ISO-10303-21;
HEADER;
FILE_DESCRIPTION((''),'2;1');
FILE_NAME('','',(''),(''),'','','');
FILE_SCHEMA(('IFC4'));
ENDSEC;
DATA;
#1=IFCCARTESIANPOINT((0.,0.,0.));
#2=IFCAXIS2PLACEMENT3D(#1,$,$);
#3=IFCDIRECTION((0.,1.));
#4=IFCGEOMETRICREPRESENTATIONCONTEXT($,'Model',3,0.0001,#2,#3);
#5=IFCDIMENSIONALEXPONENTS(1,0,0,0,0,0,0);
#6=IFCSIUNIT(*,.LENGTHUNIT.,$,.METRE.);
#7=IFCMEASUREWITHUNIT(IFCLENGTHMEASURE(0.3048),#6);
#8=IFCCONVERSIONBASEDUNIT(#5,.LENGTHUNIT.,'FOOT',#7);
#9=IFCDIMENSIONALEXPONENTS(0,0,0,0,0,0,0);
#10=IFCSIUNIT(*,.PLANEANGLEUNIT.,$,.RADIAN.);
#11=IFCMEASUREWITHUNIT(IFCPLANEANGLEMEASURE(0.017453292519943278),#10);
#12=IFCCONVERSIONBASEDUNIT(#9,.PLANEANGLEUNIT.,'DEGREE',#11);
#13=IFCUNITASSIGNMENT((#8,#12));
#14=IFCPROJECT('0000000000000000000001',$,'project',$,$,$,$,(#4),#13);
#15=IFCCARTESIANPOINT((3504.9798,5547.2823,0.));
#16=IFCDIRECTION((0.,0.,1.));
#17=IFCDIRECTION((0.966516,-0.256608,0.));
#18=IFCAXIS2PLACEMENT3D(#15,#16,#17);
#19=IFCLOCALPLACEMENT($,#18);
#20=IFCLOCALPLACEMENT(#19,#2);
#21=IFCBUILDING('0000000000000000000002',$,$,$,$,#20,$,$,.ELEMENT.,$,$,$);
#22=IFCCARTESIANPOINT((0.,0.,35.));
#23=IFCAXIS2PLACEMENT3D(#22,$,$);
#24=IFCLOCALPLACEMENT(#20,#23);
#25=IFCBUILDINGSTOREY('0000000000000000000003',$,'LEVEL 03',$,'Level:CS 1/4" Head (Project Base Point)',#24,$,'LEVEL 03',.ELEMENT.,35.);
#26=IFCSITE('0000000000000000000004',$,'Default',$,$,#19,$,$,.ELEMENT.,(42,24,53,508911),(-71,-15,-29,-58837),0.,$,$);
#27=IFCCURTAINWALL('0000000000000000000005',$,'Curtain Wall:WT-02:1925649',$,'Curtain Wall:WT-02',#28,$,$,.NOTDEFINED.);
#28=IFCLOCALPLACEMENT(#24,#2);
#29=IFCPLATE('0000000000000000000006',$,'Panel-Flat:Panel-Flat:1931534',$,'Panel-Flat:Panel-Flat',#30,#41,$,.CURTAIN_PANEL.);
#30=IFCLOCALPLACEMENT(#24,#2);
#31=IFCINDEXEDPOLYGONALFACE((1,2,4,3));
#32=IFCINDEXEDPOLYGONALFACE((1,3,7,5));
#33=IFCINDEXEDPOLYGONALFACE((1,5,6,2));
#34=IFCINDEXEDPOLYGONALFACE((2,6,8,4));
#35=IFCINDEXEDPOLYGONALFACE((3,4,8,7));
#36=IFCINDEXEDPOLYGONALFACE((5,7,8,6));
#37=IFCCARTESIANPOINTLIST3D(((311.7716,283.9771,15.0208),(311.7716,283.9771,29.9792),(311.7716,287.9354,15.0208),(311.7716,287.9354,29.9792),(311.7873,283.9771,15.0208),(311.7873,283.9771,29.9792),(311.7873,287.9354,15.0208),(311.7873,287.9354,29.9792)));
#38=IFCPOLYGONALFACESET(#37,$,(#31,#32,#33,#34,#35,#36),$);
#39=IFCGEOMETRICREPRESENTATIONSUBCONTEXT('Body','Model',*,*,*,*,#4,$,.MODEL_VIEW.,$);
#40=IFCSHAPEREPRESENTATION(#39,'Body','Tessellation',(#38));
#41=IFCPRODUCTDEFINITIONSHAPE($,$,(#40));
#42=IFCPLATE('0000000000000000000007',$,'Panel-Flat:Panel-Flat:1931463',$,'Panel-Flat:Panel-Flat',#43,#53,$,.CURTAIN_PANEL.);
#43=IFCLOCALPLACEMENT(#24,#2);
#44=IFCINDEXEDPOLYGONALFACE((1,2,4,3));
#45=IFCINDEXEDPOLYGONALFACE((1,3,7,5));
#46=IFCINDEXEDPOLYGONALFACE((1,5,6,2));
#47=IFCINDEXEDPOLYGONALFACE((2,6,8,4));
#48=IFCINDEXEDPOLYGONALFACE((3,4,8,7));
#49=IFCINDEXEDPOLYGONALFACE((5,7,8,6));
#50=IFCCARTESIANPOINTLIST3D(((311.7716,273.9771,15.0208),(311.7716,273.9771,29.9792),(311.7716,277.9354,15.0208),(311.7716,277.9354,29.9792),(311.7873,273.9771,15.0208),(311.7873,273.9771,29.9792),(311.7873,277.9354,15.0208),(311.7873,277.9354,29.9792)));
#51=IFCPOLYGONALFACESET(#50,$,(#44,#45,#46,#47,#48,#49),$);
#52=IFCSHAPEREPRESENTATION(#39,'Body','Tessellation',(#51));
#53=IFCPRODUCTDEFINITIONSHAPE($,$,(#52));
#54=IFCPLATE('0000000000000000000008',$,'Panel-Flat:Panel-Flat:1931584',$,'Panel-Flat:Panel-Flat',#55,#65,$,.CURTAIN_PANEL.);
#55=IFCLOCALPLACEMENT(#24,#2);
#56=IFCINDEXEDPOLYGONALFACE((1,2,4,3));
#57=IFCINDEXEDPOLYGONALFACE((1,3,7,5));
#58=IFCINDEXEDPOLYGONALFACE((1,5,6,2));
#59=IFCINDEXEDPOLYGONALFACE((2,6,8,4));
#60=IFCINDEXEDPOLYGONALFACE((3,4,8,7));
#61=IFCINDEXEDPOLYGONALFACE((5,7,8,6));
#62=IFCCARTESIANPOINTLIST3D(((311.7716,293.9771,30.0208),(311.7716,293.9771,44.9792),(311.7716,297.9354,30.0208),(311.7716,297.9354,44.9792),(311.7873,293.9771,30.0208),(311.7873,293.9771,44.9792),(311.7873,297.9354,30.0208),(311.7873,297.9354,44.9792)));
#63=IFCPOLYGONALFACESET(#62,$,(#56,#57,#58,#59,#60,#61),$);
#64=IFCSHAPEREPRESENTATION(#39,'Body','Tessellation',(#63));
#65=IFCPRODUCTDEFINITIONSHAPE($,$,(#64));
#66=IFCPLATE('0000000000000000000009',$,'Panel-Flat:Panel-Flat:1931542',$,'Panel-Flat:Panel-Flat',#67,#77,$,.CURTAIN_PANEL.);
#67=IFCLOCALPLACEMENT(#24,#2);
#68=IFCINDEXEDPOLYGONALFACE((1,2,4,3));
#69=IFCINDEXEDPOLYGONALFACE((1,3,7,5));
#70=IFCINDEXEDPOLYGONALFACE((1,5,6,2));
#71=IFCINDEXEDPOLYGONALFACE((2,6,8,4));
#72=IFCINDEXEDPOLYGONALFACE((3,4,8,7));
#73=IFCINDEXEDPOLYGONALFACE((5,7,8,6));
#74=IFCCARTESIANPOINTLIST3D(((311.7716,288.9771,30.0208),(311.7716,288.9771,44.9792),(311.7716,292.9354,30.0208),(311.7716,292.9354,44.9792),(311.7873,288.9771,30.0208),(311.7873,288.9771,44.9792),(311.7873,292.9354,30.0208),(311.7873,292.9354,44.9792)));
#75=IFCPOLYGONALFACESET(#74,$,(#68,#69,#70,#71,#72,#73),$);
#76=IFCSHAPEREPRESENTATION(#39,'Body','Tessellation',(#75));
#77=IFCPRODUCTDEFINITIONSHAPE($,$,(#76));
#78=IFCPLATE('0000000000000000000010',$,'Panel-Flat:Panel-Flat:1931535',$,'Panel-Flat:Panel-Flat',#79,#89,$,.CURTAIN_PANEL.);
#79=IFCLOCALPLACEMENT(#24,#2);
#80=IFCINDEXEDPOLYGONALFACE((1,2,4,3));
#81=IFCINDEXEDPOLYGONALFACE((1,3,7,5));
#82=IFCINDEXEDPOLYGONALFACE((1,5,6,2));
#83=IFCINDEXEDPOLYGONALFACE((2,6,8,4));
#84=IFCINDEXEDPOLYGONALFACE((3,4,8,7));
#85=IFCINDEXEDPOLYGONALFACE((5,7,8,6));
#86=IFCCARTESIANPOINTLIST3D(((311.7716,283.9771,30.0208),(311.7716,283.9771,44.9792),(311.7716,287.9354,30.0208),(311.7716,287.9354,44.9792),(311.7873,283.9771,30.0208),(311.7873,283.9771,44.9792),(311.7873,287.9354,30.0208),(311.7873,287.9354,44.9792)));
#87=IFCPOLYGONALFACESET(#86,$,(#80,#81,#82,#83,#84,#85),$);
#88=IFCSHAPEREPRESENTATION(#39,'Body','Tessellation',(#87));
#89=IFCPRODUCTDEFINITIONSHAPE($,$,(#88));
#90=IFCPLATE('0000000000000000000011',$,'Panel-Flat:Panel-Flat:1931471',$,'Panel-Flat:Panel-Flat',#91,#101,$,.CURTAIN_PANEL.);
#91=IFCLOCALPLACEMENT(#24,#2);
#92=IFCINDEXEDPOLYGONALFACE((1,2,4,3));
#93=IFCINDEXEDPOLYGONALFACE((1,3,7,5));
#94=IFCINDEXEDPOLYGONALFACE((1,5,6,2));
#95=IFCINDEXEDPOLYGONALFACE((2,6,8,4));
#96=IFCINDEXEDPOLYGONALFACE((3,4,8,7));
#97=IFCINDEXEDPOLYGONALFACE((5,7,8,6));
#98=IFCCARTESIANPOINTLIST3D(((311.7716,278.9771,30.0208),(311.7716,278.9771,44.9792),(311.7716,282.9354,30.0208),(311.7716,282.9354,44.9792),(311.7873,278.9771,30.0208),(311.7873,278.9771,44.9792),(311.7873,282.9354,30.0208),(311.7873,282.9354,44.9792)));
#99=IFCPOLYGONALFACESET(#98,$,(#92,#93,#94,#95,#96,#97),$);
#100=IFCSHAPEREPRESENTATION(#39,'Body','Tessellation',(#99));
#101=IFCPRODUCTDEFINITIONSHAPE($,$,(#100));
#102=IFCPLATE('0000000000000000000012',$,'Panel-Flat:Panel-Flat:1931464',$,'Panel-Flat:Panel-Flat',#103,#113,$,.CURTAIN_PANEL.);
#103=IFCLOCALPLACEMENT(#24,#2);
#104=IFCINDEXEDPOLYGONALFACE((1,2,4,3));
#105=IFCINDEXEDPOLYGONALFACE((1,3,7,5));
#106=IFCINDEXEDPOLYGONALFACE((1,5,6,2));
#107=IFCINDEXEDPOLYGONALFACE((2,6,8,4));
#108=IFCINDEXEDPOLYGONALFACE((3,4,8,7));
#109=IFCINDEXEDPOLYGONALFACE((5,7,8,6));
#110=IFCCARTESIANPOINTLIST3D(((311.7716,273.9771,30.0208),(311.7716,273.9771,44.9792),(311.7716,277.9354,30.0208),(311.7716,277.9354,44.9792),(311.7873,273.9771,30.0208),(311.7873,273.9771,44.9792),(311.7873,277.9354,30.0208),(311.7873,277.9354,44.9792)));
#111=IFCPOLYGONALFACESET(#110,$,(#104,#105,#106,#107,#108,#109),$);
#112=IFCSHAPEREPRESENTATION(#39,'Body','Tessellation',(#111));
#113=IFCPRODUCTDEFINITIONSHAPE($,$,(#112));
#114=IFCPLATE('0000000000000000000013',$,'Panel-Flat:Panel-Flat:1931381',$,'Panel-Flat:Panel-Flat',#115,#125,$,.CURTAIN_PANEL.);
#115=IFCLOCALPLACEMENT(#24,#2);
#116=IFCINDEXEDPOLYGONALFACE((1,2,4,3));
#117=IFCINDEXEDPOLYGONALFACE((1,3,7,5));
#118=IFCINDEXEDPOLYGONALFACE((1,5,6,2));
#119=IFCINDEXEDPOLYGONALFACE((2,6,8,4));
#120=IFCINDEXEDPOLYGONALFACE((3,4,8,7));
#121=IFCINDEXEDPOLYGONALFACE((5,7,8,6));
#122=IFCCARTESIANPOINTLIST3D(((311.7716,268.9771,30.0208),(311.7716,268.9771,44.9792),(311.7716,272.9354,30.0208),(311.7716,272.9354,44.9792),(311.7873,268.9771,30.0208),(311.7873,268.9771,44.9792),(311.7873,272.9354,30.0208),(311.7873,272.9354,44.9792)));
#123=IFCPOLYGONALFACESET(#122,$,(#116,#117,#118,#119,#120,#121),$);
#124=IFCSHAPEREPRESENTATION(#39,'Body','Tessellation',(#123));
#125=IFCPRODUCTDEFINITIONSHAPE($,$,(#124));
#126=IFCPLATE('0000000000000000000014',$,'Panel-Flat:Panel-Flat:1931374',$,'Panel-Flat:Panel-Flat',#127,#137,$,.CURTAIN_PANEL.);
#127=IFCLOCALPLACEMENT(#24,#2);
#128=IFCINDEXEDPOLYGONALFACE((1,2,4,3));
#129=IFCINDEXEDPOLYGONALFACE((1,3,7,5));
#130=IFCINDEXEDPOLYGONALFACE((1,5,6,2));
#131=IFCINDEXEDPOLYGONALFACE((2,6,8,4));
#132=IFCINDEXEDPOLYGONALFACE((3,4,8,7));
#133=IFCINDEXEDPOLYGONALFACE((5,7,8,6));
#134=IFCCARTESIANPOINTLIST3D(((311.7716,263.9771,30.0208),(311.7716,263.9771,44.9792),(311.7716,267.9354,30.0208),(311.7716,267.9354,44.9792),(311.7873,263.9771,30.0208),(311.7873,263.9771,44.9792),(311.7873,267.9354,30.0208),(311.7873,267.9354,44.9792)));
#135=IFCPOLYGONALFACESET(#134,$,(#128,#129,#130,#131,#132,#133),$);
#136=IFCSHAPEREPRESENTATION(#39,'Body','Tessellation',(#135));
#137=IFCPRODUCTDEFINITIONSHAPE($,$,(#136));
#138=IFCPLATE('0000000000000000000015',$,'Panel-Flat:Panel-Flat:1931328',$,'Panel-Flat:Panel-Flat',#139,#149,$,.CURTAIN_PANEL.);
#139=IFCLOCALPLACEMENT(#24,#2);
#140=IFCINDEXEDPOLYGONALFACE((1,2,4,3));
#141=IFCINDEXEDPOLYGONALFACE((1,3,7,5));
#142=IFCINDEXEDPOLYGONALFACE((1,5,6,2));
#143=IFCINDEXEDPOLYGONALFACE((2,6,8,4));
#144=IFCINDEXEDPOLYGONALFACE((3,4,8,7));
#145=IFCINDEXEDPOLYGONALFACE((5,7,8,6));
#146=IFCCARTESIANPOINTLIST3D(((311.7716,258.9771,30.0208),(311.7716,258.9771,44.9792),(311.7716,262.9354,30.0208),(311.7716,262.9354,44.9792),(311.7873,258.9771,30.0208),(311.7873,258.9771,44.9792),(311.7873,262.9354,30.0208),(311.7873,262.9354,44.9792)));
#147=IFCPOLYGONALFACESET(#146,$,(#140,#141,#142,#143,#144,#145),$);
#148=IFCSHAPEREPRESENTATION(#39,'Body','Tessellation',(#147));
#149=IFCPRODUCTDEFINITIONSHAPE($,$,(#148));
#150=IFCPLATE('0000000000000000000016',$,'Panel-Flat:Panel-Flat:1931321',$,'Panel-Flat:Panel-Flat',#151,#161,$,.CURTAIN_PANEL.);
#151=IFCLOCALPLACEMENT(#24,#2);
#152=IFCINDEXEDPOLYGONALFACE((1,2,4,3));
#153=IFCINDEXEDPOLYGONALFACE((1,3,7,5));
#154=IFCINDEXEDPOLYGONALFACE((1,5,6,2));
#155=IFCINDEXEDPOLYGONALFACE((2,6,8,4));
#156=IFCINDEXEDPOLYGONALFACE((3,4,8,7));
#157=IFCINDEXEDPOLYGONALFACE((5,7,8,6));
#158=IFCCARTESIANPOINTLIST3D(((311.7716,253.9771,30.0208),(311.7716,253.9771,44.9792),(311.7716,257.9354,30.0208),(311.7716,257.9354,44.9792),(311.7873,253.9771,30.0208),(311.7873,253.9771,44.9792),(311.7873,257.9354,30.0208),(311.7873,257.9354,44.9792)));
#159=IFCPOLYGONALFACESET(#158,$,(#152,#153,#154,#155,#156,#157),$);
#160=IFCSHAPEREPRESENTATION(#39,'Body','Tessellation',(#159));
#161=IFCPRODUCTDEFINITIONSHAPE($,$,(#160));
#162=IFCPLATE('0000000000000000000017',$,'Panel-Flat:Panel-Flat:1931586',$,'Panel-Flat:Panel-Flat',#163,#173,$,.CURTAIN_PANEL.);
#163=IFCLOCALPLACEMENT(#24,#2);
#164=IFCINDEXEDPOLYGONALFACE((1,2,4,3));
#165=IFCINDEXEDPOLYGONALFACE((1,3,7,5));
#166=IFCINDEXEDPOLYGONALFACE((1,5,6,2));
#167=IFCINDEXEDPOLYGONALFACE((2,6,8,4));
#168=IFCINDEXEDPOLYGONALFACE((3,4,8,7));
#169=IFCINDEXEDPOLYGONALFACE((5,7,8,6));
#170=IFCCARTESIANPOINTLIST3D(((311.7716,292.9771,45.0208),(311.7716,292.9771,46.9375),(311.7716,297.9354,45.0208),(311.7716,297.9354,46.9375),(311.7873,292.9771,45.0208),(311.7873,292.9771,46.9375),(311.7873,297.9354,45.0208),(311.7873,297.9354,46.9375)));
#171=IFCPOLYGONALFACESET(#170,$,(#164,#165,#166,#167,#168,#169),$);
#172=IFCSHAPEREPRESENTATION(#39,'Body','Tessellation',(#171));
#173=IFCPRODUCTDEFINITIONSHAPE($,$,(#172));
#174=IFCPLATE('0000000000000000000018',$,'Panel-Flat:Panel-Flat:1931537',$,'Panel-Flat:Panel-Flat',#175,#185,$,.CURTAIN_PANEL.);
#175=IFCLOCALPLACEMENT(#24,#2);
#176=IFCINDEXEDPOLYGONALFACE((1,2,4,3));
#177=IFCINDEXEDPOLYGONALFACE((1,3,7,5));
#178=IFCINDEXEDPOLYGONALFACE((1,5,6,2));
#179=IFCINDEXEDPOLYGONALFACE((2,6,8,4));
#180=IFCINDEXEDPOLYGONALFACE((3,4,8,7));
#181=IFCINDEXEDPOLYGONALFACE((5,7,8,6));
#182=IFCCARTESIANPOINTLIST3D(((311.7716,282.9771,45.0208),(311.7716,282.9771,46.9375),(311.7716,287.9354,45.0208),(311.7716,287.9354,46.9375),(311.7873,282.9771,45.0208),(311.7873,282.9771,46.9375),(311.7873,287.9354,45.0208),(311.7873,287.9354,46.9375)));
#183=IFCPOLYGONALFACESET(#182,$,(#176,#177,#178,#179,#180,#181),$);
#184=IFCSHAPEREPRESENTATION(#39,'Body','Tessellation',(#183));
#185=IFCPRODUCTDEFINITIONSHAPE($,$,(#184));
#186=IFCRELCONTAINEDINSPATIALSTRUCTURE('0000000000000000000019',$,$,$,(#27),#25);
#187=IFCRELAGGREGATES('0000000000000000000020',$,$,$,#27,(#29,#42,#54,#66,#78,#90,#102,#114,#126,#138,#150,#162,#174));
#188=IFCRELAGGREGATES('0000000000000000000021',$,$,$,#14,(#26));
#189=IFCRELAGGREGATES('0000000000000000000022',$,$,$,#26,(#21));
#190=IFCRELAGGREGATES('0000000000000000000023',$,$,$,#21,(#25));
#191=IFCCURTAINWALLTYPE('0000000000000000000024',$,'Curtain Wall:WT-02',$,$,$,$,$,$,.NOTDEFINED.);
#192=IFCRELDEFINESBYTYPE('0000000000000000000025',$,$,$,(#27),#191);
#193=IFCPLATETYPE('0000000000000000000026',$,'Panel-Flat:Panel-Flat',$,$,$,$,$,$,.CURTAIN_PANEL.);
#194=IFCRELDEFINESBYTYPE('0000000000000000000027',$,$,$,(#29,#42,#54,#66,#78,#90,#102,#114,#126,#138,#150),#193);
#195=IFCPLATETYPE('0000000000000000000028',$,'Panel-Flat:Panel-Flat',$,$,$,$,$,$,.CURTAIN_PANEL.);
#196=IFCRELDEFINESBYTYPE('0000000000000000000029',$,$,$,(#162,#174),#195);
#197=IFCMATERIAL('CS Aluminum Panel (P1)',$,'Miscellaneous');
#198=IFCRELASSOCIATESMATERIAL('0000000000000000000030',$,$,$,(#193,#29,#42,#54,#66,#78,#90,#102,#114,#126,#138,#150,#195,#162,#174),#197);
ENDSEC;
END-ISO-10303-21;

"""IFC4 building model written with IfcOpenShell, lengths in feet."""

from ifc_helpers import new_model, entity, si_unit, converted_unit, direction, frame, origin, place, context, subcontext, project, spatial, indexed_curve, outline, extrude, source, transform, mapped, material, type_object, type_shapes, element, aggregate, save


model = new_model("IFC4")

# Units and contexts
model_context = context("Model", 3, precision=0.0001, world=origin(), true_north=direction((0.0, 1.0)))
body_context = subcontext(model_context, "Body", "Model", "MODEL_VIEW")
ifc_project = project(units=[converted_unit("LENGTHUNIT", "FOOT", entity("IfcLengthMeasure", 0.3048), si_unit("LENGTHUNIT", "METRE"), dimensions=[1, 0, 0, 0, 0, 0, 0]), converted_unit("PLANEANGLEUNIT", "DEGREE", entity("IfcPlaneAngleMeasure", 0.017453292519943278), si_unit("PLANEANGLEUNIT", "RADIAN"), dimensions=[0, 0, 0, 0, 0, 0, 0])], contexts=[model_context])

# Site, building, storey
site_placement = place(None, frame((3504.9798, 5547.2823, 0.0), z_axis=(0.0, 0.0, 1.0), x_axis=(0.966516, -0.256608, 0.0)))
site = spatial("IfcSite", under=ifc_project, at=site_placement, Name="Default", CompositionType="ELEMENT", RefLatitude=(42, 24, 53, 508911), RefLongitude=(-71, -15, -29, -58837), RefElevation=0.0)
building_placement = place(site_placement, origin())
building = spatial("IfcBuilding", under=site, at=building_placement, CompositionType="ELEMENT")
storey_placement = place(building_placement, frame((0.0, 0.0, 35.0)))
storey = spatial("IfcBuildingStorey", under=building, at=storey_placement, Name="LEVEL 03", ObjectType="Level:CS 1/4\" Head (Project Base Point)", LongName="LEVEL 03", CompositionType="ELEMENT", Elevation=35.0)

# Curtain wall, plates
curtain_wall_type = type_object("IfcCurtainWallType", Name="Curtain Wall:WT-02", PredefinedType="NOTDEFINED")
curtain_wall_placement = place(storey_placement, frame((0.0, 0.0, -35.0)))
curtain_wall = element("IfcCurtainWall", 1, at=curtain_wall_placement, inside=storey, type_object=curtain_wall_type, Name="Curtain Wall:WT-02:1925649", ObjectType="Curtain Wall:WT-02", PredefinedType="NOTDEFINED")
ifc_material = material(Name="CS Aluminum Panel (P1)", Category="Miscellaneous")
plate_type_1 = type_object("IfcPlateType", Name="Panel-Flat:Panel-Flat", PredefinedType="CURTAIN_PANEL", material=ifc_material)
shared_shape_1 = source(origin(), body_context, "Body", "SweptSolid", [
    extrude(outline(indexed_curve([(-0.0078, -1.9792), (0.0078, -1.9792), (0.0078, 1.9792), (-0.0078, 1.9792), (-0.0078, -1.9792)], self_intersect=False)), frame((0.0, -0.0078, 0.0208), z_axis=(0.0, 0.0, 1.0), x_axis=(0.0, -1.0, 0.0)), (0.0, 0.0, 1.0), 14.9583),
])
type_shapes(plate_type_1, [shared_shape_1])
plate_1_placement = place(curtain_wall_placement, frame((311.7873, 285.9563, 50.0), z_axis=(0.0, 0.0, 1.0), x_axis=(0.0, -1.0, 0.0)))
plate_1 = element("IfcPlate", 2, at=plate_1_placement, type_object=plate_type_1, material=ifc_material, Name="Panel-Flat:Panel-Flat:1931534", ObjectType="Panel-Flat:Panel-Flat", PredefinedType="CURTAIN_PANEL", context=body_context, shape_type="MappedRepresentation", body=[
    mapped(shared_shape_1, transform((0.0, 0.0, 0.0), scale=1.0)),
])
plate_2_placement = place(curtain_wall_placement, frame((311.7873, 275.9563, 50.0), z_axis=(0.0, 0.0, 1.0), x_axis=(0.0, -1.0, 0.0)))
plate_2 = element("IfcPlate", 3, at=plate_2_placement, type_object=plate_type_1, material=ifc_material, Name="Panel-Flat:Panel-Flat:1931463", ObjectType="Panel-Flat:Panel-Flat", PredefinedType="CURTAIN_PANEL", context=body_context, shape_type="MappedRepresentation", body=[
    mapped(shared_shape_1, transform((0.0, 0.0, 0.0), scale=1.0)),
])
plate_3_placement = place(curtain_wall_placement, frame((311.7873, 295.9563, 65.0), z_axis=(0.0, 0.0, 1.0), x_axis=(0.0, -1.0, 0.0)))
plate_3 = element("IfcPlate", 4, at=plate_3_placement, type_object=plate_type_1, material=ifc_material, Name="Panel-Flat:Panel-Flat:1931584", ObjectType="Panel-Flat:Panel-Flat", PredefinedType="CURTAIN_PANEL", context=body_context, shape_type="MappedRepresentation", body=[
    mapped(shared_shape_1, transform((0.0, 0.0, 0.0), scale=1.0)),
])
plate_4_placement = place(curtain_wall_placement, frame((311.7873, 290.9563, 65.0), z_axis=(0.0, 0.0, 1.0), x_axis=(0.0, -1.0, 0.0)))
plate_4 = element("IfcPlate", 5, at=plate_4_placement, type_object=plate_type_1, material=ifc_material, Name="Panel-Flat:Panel-Flat:1931542", ObjectType="Panel-Flat:Panel-Flat", PredefinedType="CURTAIN_PANEL", context=body_context, shape_type="MappedRepresentation", body=[
    mapped(shared_shape_1, transform((0.0, 0.0, 0.0), scale=1.0)),
])
plate_5_placement = place(curtain_wall_placement, frame((311.7873, 285.9563, 65.0), z_axis=(0.0, 0.0, 1.0), x_axis=(0.0, -1.0, 0.0)))
plate_5 = element("IfcPlate", 6, at=plate_5_placement, type_object=plate_type_1, material=ifc_material, Name="Panel-Flat:Panel-Flat:1931535", ObjectType="Panel-Flat:Panel-Flat", PredefinedType="CURTAIN_PANEL", context=body_context, shape_type="MappedRepresentation", body=[
    mapped(shared_shape_1, transform((0.0, 0.0, 0.0), scale=1.0)),
])
plate_6_placement = place(curtain_wall_placement, frame((311.7873, 280.9563, 65.0), z_axis=(0.0, 0.0, 1.0), x_axis=(0.0, -1.0, 0.0)))
plate_6 = element("IfcPlate", 7, at=plate_6_placement, type_object=plate_type_1, material=ifc_material, Name="Panel-Flat:Panel-Flat:1931471", ObjectType="Panel-Flat:Panel-Flat", PredefinedType="CURTAIN_PANEL", context=body_context, shape_type="MappedRepresentation", body=[
    mapped(shared_shape_1, transform((0.0, 0.0, 0.0), scale=1.0)),
])
plate_7_placement = place(curtain_wall_placement, frame((311.7873, 275.9563, 65.0), z_axis=(0.0, 0.0, 1.0), x_axis=(0.0, -1.0, 0.0)))
plate_7 = element("IfcPlate", 8, at=plate_7_placement, type_object=plate_type_1, material=ifc_material, Name="Panel-Flat:Panel-Flat:1931464", ObjectType="Panel-Flat:Panel-Flat", PredefinedType="CURTAIN_PANEL", context=body_context, shape_type="MappedRepresentation", body=[
    mapped(shared_shape_1, transform((0.0, 0.0, 0.0), scale=1.0)),
])
plate_8_placement = place(curtain_wall_placement, frame((311.7873, 270.9563, 65.0), z_axis=(0.0, 0.0, 1.0), x_axis=(0.0, -1.0, 0.0)))
plate_8 = element("IfcPlate", 9, at=plate_8_placement, type_object=plate_type_1, material=ifc_material, Name="Panel-Flat:Panel-Flat:1931381", ObjectType="Panel-Flat:Panel-Flat", PredefinedType="CURTAIN_PANEL", context=body_context, shape_type="MappedRepresentation", body=[
    mapped(shared_shape_1, transform((0.0, 0.0, 0.0), scale=1.0)),
])
plate_9_placement = place(curtain_wall_placement, frame((311.7873, 265.9563, 65.0), z_axis=(0.0, 0.0, 1.0), x_axis=(0.0, -1.0, 0.0)))
plate_9 = element("IfcPlate", 10, at=plate_9_placement, type_object=plate_type_1, material=ifc_material, Name="Panel-Flat:Panel-Flat:1931374", ObjectType="Panel-Flat:Panel-Flat", PredefinedType="CURTAIN_PANEL", context=body_context, shape_type="MappedRepresentation", body=[
    mapped(shared_shape_1, transform((0.0, 0.0, 0.0), scale=1.0)),
])
plate_10_placement = place(curtain_wall_placement, frame((311.7873, 260.9563, 65.0), z_axis=(0.0, 0.0, 1.0), x_axis=(0.0, -1.0, 0.0)))
plate_10 = element("IfcPlate", 11, at=plate_10_placement, type_object=plate_type_1, material=ifc_material, Name="Panel-Flat:Panel-Flat:1931328", ObjectType="Panel-Flat:Panel-Flat", PredefinedType="CURTAIN_PANEL", context=body_context, shape_type="MappedRepresentation", body=[
    mapped(shared_shape_1, transform((0.0, 0.0, 0.0), scale=1.0)),
])
plate_11_placement = place(curtain_wall_placement, frame((311.7873, 255.9563, 65.0), z_axis=(0.0, 0.0, 1.0), x_axis=(0.0, -1.0, 0.0)))
plate_11 = element("IfcPlate", 12, at=plate_11_placement, type_object=plate_type_1, material=ifc_material, Name="Panel-Flat:Panel-Flat:1931321", ObjectType="Panel-Flat:Panel-Flat", PredefinedType="CURTAIN_PANEL", context=body_context, shape_type="MappedRepresentation", body=[
    mapped(shared_shape_1, transform((0.0, 0.0, 0.0), scale=1.0)),
])
plate_type_2 = type_object("IfcPlateType", Name="Panel-Flat:Panel-Flat", PredefinedType="CURTAIN_PANEL", material=ifc_material)
shared_shape_2 = source(origin(), body_context, "Body", "SweptSolid", [
    extrude(outline(indexed_curve([(-0.0078, -2.4792), (0.0078, -2.4792), (0.0078, 2.4792), (-0.0078, 2.4792), (-0.0078, -2.4792)], self_intersect=False)), frame((0.0, -0.0078, 0.0208), z_axis=(0.0, 0.0, 1.0), x_axis=(0.0, -1.0, 0.0)), (0.0, 0.0, 1.0), 1.9167),
])
type_shapes(plate_type_2, [shared_shape_2])
plate_12_placement = place(curtain_wall_placement, frame((311.7873, 295.4563, 80.0), z_axis=(0.0, 0.0, 1.0), x_axis=(0.0, -1.0, 0.0)))
plate_12 = element("IfcPlate", 13, at=plate_12_placement, type_object=plate_type_2, material=ifc_material, Name="Panel-Flat:Panel-Flat:1931586", ObjectType="Panel-Flat:Panel-Flat", PredefinedType="CURTAIN_PANEL", context=body_context, shape_type="MappedRepresentation", body=[
    mapped(shared_shape_2, transform((0.0, 0.0, 0.0), scale=1.0)),
])
plate_13_placement = place(curtain_wall_placement, frame((311.7873, 285.4563, 80.0), z_axis=(0.0, 0.0, 1.0), x_axis=(0.0, -1.0, 0.0)))
plate_13 = element("IfcPlate", 14, at=plate_13_placement, type_object=plate_type_2, material=ifc_material, Name="Panel-Flat:Panel-Flat:1931537", ObjectType="Panel-Flat:Panel-Flat", PredefinedType="CURTAIN_PANEL", context=body_context, shape_type="MappedRepresentation", body=[
    mapped(shared_shape_2, transform((0.0, 0.0, 0.0), scale=1.0)),
])
aggregate(curtain_wall, [plate_1, plate_2, plate_3, plate_4, plate_5, plate_6, plate_7, plate_8, plate_9, plate_10, plate_11, plate_12, plate_13])

save(model, "model.ifc")
